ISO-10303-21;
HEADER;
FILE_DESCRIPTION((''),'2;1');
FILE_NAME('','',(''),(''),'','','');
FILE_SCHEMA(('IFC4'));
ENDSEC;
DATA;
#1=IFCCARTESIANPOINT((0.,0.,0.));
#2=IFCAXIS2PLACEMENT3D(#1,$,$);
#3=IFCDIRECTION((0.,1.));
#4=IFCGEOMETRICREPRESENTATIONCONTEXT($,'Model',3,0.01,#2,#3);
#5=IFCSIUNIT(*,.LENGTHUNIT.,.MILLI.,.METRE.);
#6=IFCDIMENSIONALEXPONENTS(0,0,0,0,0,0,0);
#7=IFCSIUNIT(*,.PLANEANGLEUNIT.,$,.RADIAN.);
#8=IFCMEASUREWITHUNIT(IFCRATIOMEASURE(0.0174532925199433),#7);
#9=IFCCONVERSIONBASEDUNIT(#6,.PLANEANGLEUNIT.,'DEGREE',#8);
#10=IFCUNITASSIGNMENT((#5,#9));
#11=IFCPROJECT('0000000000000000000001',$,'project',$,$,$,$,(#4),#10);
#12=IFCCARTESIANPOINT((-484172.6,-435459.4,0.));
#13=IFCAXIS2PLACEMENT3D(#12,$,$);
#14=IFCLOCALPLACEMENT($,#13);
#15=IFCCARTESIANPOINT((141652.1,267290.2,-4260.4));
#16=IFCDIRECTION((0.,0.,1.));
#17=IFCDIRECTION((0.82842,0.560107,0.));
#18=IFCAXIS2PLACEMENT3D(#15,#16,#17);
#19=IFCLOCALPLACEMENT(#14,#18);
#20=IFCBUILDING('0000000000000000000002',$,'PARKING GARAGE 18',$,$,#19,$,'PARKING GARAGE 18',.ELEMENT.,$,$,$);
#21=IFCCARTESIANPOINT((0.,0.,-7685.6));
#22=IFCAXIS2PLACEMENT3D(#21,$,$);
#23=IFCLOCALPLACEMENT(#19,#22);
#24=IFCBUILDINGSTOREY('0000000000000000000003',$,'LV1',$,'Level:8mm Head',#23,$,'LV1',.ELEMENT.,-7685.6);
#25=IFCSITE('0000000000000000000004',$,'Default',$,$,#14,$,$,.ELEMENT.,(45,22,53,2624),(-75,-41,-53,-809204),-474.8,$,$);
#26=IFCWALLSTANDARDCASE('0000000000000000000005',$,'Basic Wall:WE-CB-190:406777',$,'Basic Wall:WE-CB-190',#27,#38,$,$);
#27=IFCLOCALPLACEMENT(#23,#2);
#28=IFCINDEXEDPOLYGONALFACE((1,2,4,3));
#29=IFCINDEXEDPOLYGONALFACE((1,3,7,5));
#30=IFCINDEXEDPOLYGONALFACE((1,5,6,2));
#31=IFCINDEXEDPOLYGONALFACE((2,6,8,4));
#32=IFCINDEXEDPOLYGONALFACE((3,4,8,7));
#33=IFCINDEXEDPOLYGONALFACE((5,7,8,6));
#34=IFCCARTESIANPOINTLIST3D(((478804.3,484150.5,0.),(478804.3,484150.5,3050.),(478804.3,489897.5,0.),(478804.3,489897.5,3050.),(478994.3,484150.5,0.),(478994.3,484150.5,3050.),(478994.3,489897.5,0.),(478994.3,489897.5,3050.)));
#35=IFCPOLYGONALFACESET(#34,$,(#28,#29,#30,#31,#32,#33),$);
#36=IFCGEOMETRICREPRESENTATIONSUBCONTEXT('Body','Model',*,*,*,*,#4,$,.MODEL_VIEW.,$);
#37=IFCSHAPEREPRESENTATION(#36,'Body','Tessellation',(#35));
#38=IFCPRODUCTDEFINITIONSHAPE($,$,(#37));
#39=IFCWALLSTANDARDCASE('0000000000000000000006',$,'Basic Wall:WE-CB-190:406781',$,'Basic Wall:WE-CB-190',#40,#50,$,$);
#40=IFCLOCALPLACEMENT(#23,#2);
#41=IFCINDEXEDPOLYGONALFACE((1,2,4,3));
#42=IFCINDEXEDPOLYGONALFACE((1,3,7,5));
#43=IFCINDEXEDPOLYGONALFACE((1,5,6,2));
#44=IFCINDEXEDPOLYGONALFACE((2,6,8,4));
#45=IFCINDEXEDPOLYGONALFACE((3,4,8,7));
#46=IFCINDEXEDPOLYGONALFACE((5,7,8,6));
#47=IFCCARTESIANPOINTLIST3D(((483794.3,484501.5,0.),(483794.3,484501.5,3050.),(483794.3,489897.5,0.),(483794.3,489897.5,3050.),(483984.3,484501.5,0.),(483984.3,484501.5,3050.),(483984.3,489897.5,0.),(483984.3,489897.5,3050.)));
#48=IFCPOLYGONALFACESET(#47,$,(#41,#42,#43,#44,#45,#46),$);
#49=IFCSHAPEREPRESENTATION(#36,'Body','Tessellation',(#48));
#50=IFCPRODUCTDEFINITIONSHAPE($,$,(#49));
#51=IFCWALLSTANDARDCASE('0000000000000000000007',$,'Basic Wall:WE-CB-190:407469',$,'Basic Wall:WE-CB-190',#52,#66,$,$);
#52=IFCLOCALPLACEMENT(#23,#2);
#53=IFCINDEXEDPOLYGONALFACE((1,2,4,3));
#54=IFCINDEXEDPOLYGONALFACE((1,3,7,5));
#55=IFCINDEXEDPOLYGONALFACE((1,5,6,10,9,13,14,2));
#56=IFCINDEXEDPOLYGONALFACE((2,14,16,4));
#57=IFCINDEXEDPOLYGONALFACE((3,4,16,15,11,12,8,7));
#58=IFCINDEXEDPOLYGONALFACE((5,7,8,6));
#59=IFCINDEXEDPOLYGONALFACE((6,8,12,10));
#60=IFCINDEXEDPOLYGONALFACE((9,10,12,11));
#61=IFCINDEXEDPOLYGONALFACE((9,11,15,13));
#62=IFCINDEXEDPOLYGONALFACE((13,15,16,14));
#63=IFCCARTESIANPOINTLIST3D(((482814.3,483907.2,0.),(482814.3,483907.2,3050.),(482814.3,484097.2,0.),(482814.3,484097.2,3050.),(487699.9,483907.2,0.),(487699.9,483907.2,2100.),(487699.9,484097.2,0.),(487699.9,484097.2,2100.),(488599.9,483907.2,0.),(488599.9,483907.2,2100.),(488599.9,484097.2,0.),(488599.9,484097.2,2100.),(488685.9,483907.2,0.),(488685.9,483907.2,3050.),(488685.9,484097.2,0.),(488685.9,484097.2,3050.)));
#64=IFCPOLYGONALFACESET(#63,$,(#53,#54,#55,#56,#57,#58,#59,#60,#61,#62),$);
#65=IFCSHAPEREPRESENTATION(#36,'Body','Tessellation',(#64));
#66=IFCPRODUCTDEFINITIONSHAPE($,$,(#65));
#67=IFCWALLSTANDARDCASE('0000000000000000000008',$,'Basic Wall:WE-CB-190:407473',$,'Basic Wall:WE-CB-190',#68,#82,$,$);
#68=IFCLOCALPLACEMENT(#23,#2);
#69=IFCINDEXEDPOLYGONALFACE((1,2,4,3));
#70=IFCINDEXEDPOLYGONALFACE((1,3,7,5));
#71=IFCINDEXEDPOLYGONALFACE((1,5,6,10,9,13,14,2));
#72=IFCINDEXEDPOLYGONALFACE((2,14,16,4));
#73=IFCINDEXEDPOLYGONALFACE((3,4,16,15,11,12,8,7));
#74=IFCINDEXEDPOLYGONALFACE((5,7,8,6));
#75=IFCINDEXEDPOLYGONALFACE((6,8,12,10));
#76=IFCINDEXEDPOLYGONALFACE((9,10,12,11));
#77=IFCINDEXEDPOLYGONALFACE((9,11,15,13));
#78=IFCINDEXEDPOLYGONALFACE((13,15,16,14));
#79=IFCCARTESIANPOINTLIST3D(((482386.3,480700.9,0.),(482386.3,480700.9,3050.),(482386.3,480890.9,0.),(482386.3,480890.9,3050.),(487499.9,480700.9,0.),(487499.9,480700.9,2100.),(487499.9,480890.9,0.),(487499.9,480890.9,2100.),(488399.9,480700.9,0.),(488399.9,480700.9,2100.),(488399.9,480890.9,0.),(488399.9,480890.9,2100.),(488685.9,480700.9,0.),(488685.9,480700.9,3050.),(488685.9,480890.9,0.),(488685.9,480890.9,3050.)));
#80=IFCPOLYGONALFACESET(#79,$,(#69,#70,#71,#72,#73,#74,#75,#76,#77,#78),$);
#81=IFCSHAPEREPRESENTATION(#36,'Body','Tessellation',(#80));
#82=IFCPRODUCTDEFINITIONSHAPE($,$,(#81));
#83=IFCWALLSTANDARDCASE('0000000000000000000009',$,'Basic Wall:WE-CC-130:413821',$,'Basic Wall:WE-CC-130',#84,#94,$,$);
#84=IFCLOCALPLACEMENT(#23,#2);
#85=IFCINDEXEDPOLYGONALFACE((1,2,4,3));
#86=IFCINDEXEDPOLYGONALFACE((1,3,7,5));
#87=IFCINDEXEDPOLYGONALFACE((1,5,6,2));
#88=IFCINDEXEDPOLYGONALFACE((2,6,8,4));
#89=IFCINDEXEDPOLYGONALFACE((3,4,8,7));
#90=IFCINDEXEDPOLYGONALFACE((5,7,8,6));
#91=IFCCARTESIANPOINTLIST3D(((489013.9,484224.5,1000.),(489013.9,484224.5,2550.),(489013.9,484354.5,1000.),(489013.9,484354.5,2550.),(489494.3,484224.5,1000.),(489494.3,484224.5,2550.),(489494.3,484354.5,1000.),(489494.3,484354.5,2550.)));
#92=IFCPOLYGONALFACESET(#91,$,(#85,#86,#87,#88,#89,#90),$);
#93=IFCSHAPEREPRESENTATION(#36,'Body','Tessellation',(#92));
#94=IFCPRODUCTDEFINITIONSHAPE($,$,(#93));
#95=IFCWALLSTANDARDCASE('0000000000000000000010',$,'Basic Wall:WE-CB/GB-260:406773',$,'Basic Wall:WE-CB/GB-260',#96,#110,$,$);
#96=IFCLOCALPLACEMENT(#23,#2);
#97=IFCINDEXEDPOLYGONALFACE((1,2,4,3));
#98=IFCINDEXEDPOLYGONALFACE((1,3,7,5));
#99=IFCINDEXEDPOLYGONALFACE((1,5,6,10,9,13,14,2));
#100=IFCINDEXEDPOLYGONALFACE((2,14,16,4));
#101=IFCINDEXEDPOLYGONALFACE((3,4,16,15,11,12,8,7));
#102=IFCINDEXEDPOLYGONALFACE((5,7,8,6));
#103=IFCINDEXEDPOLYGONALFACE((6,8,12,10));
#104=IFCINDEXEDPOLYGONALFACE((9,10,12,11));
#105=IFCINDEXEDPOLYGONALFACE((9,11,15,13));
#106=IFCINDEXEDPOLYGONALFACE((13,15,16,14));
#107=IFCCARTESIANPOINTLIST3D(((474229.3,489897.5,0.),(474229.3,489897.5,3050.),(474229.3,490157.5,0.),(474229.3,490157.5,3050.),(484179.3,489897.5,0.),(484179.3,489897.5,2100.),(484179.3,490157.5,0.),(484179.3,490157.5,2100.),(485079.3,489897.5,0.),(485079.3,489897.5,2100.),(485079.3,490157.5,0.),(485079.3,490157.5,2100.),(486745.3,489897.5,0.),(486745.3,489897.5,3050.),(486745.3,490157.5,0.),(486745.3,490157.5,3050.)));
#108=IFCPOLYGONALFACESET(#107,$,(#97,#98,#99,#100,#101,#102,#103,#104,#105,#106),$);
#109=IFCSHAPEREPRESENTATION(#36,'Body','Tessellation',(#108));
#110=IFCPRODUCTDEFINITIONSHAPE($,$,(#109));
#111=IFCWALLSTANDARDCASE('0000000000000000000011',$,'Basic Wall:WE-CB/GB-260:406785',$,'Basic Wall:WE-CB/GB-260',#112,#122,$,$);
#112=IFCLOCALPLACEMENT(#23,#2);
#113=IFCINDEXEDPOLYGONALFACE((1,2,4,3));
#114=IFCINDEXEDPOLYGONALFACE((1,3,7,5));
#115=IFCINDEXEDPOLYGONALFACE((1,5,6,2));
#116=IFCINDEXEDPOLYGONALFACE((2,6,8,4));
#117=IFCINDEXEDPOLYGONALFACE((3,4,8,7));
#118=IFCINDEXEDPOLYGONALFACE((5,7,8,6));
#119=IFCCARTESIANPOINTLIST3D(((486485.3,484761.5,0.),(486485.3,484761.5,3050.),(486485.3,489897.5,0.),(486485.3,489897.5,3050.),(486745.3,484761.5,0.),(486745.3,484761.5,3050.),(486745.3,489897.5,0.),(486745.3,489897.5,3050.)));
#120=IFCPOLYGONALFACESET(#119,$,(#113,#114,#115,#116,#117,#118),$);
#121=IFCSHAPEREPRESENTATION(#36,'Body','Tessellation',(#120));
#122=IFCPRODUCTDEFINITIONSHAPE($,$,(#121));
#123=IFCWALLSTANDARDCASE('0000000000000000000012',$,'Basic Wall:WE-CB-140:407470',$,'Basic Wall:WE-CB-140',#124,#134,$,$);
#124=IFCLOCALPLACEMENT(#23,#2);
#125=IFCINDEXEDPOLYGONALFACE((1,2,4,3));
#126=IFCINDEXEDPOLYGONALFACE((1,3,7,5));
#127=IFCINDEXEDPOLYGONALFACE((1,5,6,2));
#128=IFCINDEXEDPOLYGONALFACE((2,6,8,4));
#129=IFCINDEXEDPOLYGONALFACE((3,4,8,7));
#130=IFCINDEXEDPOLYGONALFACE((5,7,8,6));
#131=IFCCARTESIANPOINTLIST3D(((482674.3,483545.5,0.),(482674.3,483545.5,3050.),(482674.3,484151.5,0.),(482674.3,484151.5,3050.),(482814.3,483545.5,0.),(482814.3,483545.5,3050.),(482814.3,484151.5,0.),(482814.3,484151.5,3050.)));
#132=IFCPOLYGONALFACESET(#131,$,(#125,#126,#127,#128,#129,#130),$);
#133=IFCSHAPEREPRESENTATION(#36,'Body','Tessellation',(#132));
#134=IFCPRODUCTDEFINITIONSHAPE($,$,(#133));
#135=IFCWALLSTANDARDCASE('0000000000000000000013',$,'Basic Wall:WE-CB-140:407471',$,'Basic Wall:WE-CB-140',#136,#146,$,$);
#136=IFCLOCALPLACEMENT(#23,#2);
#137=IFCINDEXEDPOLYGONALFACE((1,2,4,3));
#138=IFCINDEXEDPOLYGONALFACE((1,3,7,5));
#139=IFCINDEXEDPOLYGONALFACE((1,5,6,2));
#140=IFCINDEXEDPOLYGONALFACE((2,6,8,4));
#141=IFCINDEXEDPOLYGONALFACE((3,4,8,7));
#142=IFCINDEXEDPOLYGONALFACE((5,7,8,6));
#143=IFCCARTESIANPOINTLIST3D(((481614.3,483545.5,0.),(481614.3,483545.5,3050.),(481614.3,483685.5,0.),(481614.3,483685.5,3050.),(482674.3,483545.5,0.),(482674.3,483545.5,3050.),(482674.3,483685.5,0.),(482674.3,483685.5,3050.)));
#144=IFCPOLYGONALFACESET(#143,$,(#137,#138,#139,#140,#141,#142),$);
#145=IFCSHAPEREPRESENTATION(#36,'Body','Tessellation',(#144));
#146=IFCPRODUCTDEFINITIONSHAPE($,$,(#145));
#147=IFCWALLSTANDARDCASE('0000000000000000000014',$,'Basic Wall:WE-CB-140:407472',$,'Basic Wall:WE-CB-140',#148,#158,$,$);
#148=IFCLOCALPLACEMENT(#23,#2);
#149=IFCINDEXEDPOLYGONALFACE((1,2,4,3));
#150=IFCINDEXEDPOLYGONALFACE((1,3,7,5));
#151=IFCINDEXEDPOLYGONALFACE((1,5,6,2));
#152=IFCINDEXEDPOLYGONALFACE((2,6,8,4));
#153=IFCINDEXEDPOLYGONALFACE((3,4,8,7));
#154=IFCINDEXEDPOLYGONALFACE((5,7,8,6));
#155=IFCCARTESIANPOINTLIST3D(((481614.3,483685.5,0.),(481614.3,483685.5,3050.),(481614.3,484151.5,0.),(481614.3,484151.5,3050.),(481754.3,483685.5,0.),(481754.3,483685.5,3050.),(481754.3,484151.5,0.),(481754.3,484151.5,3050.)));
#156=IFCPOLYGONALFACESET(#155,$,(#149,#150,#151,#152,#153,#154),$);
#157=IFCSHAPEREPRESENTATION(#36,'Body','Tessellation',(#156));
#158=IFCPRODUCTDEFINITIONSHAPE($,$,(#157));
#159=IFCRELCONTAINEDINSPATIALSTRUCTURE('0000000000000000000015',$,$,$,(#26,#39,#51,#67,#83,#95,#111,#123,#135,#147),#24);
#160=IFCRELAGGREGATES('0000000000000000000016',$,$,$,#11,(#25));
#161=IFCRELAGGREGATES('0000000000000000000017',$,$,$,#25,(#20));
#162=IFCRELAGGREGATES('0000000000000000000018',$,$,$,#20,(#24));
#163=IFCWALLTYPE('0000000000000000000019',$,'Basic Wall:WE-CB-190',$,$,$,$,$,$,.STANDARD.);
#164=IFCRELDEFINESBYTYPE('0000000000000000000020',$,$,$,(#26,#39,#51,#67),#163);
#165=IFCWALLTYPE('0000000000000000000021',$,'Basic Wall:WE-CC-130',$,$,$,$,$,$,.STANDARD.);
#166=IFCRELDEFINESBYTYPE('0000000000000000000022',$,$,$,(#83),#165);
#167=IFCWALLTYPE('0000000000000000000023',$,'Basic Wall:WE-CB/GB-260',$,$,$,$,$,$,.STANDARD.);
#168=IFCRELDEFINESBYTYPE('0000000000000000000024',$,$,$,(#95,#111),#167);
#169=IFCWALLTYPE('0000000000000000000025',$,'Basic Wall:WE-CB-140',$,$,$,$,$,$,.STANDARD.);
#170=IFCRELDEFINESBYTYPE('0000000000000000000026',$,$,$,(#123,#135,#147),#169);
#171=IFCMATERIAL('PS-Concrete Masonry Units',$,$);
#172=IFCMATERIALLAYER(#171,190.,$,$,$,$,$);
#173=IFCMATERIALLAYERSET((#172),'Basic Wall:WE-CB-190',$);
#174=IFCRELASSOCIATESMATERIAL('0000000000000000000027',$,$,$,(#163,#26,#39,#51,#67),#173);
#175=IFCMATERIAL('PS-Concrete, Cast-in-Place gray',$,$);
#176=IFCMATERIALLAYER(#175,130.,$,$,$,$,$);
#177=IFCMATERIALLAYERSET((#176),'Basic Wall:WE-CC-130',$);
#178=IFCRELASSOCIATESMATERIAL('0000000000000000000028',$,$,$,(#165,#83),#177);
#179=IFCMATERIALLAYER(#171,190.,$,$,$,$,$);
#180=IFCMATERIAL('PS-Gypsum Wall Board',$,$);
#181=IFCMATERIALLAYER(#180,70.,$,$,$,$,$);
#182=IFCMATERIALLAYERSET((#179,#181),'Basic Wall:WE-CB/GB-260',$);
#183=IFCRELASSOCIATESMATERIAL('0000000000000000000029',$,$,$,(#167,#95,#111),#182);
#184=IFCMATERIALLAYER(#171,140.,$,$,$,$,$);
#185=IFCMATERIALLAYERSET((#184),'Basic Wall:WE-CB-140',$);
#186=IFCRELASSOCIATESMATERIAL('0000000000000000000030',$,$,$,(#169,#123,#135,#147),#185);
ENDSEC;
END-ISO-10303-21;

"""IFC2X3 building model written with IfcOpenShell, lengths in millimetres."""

from ifc_helpers import new_model, entity, si_unit, converted_unit, direction, frame, frame_2d, origin, place, context, subcontext, project, spatial, rectangle, extrude, material, layer, layer_set, layer_usage, type_object, element, save


model = new_model("IFC2X3")

# Units and contexts
model_context = context("Model", 3, precision=0.01, world=origin(), true_north=direction((0.0, 1.0)))
body_context = subcontext(model_context, "Body", "Model", "MODEL_VIEW")
ifc_project = project(units=[si_unit("LENGTHUNIT", "METRE", prefix="MILLI"), converted_unit("PLANEANGLEUNIT", "DEGREE", entity("IfcRatioMeasure", 0.0174532925199433), si_unit("PLANEANGLEUNIT", "RADIAN"), dimensions=[0, 0, 0, 0, 0, 0, 0])], contexts=[model_context])

# Site, building, storey
site_placement = place(None, frame((-484172.6, -435459.4, 0.0)))
site = spatial("IfcSite", under=ifc_project, at=site_placement, Name="Default", CompositionType="ELEMENT", RefLatitude=(45, 22, 53, 2624), RefLongitude=(-75, -41, -53, -809204), RefElevation=-474.8)
building_placement = place(site_placement, frame((141652.1, 267290.2, -4260.4), z_axis=(0.0, 0.0, 1.0), x_axis=(0.82842, 0.560107, 0.0)))
building = spatial("IfcBuilding", under=site, at=building_placement, Name="PARKING GARAGE 18", LongName="PARKING GARAGE 18", CompositionType="ELEMENT")
storey_placement = place(building_placement, frame((0.0, 0.0, -7685.6)))
storey = spatial("IfcBuildingStorey", under=building, at=storey_placement, Name="LV1", ObjectType="Level:8mm Head", LongName="LV1", CompositionType="ELEMENT", Elevation=-7685.6)

# Shared definitions
ifc_material_1 = material(Name="PS-Concrete, Cast-in-Place gray")

# Shared definitions
ifc_material_2 = material(Name="PS-Concrete Masonry Units")

# Walls
ifc_layer_1 = layer(ifc_material_2, 190.0)
ifc_layer_set_1 = layer_set([ifc_layer_1], Name="Basic Wall:WE-CB-190")
ifc_layer_usage_1 = layer_usage(ifc_layer_set_1, "AXIS2", "NEGATIVE", 95.0)
wall_type_1 = type_object("IfcWallType", Name="Basic Wall:WE-CB-190", PredefinedType="STANDARD", material=ifc_layer_set_1)
wall_1_placement = place(storey_placement, frame((478899.3, 484150.5, 0.0), z_axis=(0.0, 0.0, 1.0), x_axis=(0.0, 1.0, 0.0)))
element("IfcWallStandardCase", 1, at=wall_1_placement, inside=storey, type_object=wall_type_1, material=ifc_layer_usage_1, Name="Basic Wall:WE-CB-190:406777", ObjectType="Basic Wall:WE-CB-190", context=body_context, shape_type="SweptSolid", body=[
    extrude(rectangle(XDim=5747.0, YDim=190.0, at=frame_2d((2873.5, 0.0), x_axis=(-1.0, 0.0))), origin(), (0.0, 0.0, 1.0), 3050.0),
])
ifc_layer_usage_2 = layer_usage(ifc_layer_set_1, "AXIS2", "NEGATIVE", 95.0)
wall_2_placement = place(storey_placement, frame((483889.3, 489897.5, 0.0), z_axis=(0.0, 0.0, 1.0), x_axis=(0.0, -1.0, 0.0)))
element("IfcWallStandardCase", 2, at=wall_2_placement, inside=storey, type_object=wall_type_1, material=ifc_layer_usage_2, Name="Basic Wall:WE-CB-190:406781", ObjectType="Basic Wall:WE-CB-190", context=body_context, shape_type="SweptSolid", body=[
    extrude(rectangle(XDim=5396.0, YDim=190.0, at=frame_2d((2698.0, 0.0), x_axis=(-1.0, 0.0))), origin(), (0.0, 0.0, 1.0), 3050.0),
])

# Walls, openings
ifc_layer_usage_3 = layer_usage(ifc_layer_set_1, "AXIS2", "NEGATIVE", 95.0)
wall_3_placement = place(storey_placement, frame((482814.3, 484002.2, 0.0)))
wall_3 = element("IfcWallStandardCase", 3, at=wall_3_placement, inside=storey, type_object=wall_type_1, material=ifc_layer_usage_3, Name="Basic Wall:WE-CB-190:407469", ObjectType="Basic Wall:WE-CB-190", context=body_context, shape_type="SweptSolid", body=[
    extrude(rectangle(XDim=5871.6, YDim=190.0, at=frame_2d((2935.8, 0.0), x_axis=(-1.0, 0.0))), origin(), (0.0, 0.0, 1.0), 3050.0),
])
opening_1_placement = place(wall_3_placement, origin())
element("IfcOpeningElement", 4, at=opening_1_placement, cuts=wall_3, ObjectType="Opening", context=body_context, shape_type="SweptSolid", body=[
    extrude(rectangle(XDim=2100.0, YDim=900.0, at=frame_2d((0.0, 0.0), x_axis=(1.0, 0.0))), frame((5335.6, -1429.0, 1050.0), z_axis=(0.0, 1.0, 0.0), x_axis=(0.0, 0.0, 1.0)), (0.0, 0.0, 1.0), 3048.0),
])
ifc_layer_usage_4 = layer_usage(ifc_layer_set_1, "AXIS2", "NEGATIVE", 95.0)
wall_4_placement = place(storey_placement, frame((488685.9, 480795.9, 0.0), z_axis=(0.0, 0.0, 1.0), x_axis=(-1.0, 0.0, 0.0)))
wall_4 = element("IfcWallStandardCase", 5, at=wall_4_placement, inside=storey, type_object=wall_type_1, material=ifc_layer_usage_4, Name="Basic Wall:WE-CB-190:407473", ObjectType="Basic Wall:WE-CB-190", context=body_context, shape_type="SweptSolid", body=[
    extrude(rectangle(XDim=6299.6, YDim=190.0, at=frame_2d((3149.8, 0.0), x_axis=(-1.0, 0.0))), origin(), (0.0, 0.0, 1.0), 3050.0),
])
opening_2_placement = place(wall_4_placement, origin())
element("IfcOpeningElement", 6, at=opening_2_placement, cuts=wall_4, ObjectType="Opening", context=body_context, shape_type="SweptSolid", body=[
    extrude(rectangle(XDim=2100.0, YDim=900.0, at=frame_2d((0.0, 0.0), x_axis=(0.0, 1.0))), frame((736.0, -1619.0, 1050.0), z_axis=(0.0, 1.0, 0.0), x_axis=(-1.0, 0.0, 0.0)), (0.0, 0.0, 1.0), 3048.0),
])

# Wall
ifc_layer_2 = layer(ifc_material_1, 130.0)
ifc_layer_set_2 = layer_set([ifc_layer_2], Name="Basic Wall:WE-CC-130")
ifc_layer_usage_5 = layer_usage(ifc_layer_set_2, "AXIS2", "NEGATIVE", 65.0)
wall_type_2 = type_object("IfcWallType", Name="Basic Wall:WE-CC-130", PredefinedType="STANDARD", material=ifc_layer_set_2)
wall_5_placement = place(storey_placement, frame((489494.3, 484289.5, 1000.0), z_axis=(0.0, 0.0, 1.0), x_axis=(-1.0, 0.0, 0.0)))
element("IfcWallStandardCase", 7, at=wall_5_placement, inside=storey, type_object=wall_type_2, material=ifc_layer_usage_5, Name="Basic Wall:WE-CC-130:413821", ObjectType="Basic Wall:WE-CC-130", context=body_context, shape_type="SweptSolid", body=[
    extrude(rectangle(XDim=480.4, YDim=130.0, at=frame_2d((240.2, 0.0), x_axis=(-1.0, 0.0))), origin(), (0.0, 0.0, 1.0), 1550.0),
])

# Wall, opening
ifc_layer_3 = layer(ifc_material_2, 190.0)
ifc_material_3 = material(Name="PS-Gypsum Wall Board")
ifc_layer_4 = layer(ifc_material_3, 70.0)
ifc_layer_set_3 = layer_set([ifc_layer_3, ifc_layer_4], Name="Basic Wall:WE-CB/GB-260")
ifc_layer_usage_6 = layer_usage(ifc_layer_set_3, "AXIS2", "NEGATIVE", 130.0)
wall_type_3 = type_object("IfcWallType", Name="Basic Wall:WE-CB/GB-260", PredefinedType="STANDARD", material=ifc_layer_set_3)
wall_6_placement = place(storey_placement, frame((474229.3, 490027.5, 0.0)))
wall_6 = element("IfcWallStandardCase", 8, at=wall_6_placement, inside=storey, type_object=wall_type_3, material=ifc_layer_usage_6, Name="Basic Wall:WE-CB/GB-260:406773", ObjectType="Basic Wall:WE-CB/GB-260", context=body_context, shape_type="SweptSolid", body=[
    extrude(rectangle(XDim=12516.0, YDim=260.0, at=frame_2d((6258.0, 0.0), x_axis=(-1.0, 0.0))), origin(), (0.0, 0.0, 1.0), 3050.0),
])
opening_3_placement = place(wall_6_placement, origin())
element("IfcOpeningElement", 9, at=opening_3_placement, cuts=wall_6, ObjectType="Opening", context=body_context, shape_type="SweptSolid", body=[
    extrude(rectangle(XDim=2100.0, YDim=900.0, at=frame_2d((0.0, 0.0), x_axis=(0.0, 1.0))), frame((10400.0, -1394.0, 1050.0), z_axis=(0.0, 1.0, 0.0), x_axis=(-1.0, 0.0, 0.0)), (0.0, 0.0, 1.0), 3048.0),
])

# Walls
ifc_layer_usage_7 = layer_usage(ifc_layer_set_3, "AXIS2", "POSITIVE", -130.0)
wall_7_placement = place(storey_placement, frame((486615.3, 484761.5, 0.0), z_axis=(0.0, 0.0, 1.0), x_axis=(0.0, 1.0, 0.0)))
element("IfcWallStandardCase", 10, at=wall_7_placement, inside=storey, type_object=wall_type_3, material=ifc_layer_usage_7, Name="Basic Wall:WE-CB/GB-260:406785", ObjectType="Basic Wall:WE-CB/GB-260", context=body_context, shape_type="SweptSolid", body=[
    extrude(rectangle(XDim=5136.0, YDim=260.0, at=frame_2d((2568.0, 0.0), x_axis=(-1.0, 0.0))), origin(), (0.0, 0.0, 1.0), 3050.0),
])
ifc_layer_5 = layer(ifc_material_2, 140.0)
ifc_layer_set_4 = layer_set([ifc_layer_5], Name="Basic Wall:WE-CB-140")
ifc_layer_usage_8 = layer_usage(ifc_layer_set_4, "AXIS2", "NEGATIVE", 70.0)
wall_type_4 = type_object("IfcWallType", Name="Basic Wall:WE-CB-140", PredefinedType="STANDARD", material=ifc_layer_set_4)
wall_8_placement = place(storey_placement, frame((482744.3, 483545.5, 0.0), z_axis=(0.0, 0.0, 1.0), x_axis=(0.0, 1.0, 0.0)))
element("IfcWallStandardCase", 11, at=wall_8_placement, inside=storey, type_object=wall_type_4, material=ifc_layer_usage_8, Name="Basic Wall:WE-CB-140:407470", ObjectType="Basic Wall:WE-CB-140", context=body_context, shape_type="SweptSolid", body=[
    extrude(rectangle(XDim=606.0, YDim=140.0, at=frame_2d((303.0, 0.0), x_axis=(-1.0, 0.0))), origin(), (0.0, 0.0, 1.0), 3050.0),
])
ifc_layer_usage_9 = layer_usage(ifc_layer_set_4, "AXIS2", "NEGATIVE", 70.0)
wall_9_placement = place(storey_placement, frame((481614.3, 483615.5, 0.0)))
element("IfcWallStandardCase", 12, at=wall_9_placement, inside=storey, type_object=wall_type_4, material=ifc_layer_usage_9, Name="Basic Wall:WE-CB-140:407471", ObjectType="Basic Wall:WE-CB-140", context=body_context, shape_type="SweptSolid", body=[
    extrude(rectangle(XDim=1060.0, YDim=140.0, at=frame_2d((530.0, 0.0), x_axis=(-1.0, 0.0))), origin(), (0.0, 0.0, 1.0), 3050.0),
])
ifc_layer_usage_10 = layer_usage(ifc_layer_set_4, "AXIS2", "NEGATIVE", 70.0)
wall_10_placement = place(storey_placement, frame((481684.3, 484151.5, 0.0), z_axis=(0.0, 0.0, 1.0), x_axis=(0.0, -1.0, 0.0)))
element("IfcWallStandardCase", 13, at=wall_10_placement, inside=storey, type_object=wall_type_4, material=ifc_layer_usage_10, Name="Basic Wall:WE-CB-140:407472", ObjectType="Basic Wall:WE-CB-140", context=body_context, shape_type="SweptSolid", body=[
    extrude(rectangle(XDim=466.0, YDim=140.0, at=frame_2d((233.0, 0.0), x_axis=(-1.0, 0.0))), origin(), (0.0, 0.0, 1.0), 3050.0),
])

save(model, "model.ifc")
